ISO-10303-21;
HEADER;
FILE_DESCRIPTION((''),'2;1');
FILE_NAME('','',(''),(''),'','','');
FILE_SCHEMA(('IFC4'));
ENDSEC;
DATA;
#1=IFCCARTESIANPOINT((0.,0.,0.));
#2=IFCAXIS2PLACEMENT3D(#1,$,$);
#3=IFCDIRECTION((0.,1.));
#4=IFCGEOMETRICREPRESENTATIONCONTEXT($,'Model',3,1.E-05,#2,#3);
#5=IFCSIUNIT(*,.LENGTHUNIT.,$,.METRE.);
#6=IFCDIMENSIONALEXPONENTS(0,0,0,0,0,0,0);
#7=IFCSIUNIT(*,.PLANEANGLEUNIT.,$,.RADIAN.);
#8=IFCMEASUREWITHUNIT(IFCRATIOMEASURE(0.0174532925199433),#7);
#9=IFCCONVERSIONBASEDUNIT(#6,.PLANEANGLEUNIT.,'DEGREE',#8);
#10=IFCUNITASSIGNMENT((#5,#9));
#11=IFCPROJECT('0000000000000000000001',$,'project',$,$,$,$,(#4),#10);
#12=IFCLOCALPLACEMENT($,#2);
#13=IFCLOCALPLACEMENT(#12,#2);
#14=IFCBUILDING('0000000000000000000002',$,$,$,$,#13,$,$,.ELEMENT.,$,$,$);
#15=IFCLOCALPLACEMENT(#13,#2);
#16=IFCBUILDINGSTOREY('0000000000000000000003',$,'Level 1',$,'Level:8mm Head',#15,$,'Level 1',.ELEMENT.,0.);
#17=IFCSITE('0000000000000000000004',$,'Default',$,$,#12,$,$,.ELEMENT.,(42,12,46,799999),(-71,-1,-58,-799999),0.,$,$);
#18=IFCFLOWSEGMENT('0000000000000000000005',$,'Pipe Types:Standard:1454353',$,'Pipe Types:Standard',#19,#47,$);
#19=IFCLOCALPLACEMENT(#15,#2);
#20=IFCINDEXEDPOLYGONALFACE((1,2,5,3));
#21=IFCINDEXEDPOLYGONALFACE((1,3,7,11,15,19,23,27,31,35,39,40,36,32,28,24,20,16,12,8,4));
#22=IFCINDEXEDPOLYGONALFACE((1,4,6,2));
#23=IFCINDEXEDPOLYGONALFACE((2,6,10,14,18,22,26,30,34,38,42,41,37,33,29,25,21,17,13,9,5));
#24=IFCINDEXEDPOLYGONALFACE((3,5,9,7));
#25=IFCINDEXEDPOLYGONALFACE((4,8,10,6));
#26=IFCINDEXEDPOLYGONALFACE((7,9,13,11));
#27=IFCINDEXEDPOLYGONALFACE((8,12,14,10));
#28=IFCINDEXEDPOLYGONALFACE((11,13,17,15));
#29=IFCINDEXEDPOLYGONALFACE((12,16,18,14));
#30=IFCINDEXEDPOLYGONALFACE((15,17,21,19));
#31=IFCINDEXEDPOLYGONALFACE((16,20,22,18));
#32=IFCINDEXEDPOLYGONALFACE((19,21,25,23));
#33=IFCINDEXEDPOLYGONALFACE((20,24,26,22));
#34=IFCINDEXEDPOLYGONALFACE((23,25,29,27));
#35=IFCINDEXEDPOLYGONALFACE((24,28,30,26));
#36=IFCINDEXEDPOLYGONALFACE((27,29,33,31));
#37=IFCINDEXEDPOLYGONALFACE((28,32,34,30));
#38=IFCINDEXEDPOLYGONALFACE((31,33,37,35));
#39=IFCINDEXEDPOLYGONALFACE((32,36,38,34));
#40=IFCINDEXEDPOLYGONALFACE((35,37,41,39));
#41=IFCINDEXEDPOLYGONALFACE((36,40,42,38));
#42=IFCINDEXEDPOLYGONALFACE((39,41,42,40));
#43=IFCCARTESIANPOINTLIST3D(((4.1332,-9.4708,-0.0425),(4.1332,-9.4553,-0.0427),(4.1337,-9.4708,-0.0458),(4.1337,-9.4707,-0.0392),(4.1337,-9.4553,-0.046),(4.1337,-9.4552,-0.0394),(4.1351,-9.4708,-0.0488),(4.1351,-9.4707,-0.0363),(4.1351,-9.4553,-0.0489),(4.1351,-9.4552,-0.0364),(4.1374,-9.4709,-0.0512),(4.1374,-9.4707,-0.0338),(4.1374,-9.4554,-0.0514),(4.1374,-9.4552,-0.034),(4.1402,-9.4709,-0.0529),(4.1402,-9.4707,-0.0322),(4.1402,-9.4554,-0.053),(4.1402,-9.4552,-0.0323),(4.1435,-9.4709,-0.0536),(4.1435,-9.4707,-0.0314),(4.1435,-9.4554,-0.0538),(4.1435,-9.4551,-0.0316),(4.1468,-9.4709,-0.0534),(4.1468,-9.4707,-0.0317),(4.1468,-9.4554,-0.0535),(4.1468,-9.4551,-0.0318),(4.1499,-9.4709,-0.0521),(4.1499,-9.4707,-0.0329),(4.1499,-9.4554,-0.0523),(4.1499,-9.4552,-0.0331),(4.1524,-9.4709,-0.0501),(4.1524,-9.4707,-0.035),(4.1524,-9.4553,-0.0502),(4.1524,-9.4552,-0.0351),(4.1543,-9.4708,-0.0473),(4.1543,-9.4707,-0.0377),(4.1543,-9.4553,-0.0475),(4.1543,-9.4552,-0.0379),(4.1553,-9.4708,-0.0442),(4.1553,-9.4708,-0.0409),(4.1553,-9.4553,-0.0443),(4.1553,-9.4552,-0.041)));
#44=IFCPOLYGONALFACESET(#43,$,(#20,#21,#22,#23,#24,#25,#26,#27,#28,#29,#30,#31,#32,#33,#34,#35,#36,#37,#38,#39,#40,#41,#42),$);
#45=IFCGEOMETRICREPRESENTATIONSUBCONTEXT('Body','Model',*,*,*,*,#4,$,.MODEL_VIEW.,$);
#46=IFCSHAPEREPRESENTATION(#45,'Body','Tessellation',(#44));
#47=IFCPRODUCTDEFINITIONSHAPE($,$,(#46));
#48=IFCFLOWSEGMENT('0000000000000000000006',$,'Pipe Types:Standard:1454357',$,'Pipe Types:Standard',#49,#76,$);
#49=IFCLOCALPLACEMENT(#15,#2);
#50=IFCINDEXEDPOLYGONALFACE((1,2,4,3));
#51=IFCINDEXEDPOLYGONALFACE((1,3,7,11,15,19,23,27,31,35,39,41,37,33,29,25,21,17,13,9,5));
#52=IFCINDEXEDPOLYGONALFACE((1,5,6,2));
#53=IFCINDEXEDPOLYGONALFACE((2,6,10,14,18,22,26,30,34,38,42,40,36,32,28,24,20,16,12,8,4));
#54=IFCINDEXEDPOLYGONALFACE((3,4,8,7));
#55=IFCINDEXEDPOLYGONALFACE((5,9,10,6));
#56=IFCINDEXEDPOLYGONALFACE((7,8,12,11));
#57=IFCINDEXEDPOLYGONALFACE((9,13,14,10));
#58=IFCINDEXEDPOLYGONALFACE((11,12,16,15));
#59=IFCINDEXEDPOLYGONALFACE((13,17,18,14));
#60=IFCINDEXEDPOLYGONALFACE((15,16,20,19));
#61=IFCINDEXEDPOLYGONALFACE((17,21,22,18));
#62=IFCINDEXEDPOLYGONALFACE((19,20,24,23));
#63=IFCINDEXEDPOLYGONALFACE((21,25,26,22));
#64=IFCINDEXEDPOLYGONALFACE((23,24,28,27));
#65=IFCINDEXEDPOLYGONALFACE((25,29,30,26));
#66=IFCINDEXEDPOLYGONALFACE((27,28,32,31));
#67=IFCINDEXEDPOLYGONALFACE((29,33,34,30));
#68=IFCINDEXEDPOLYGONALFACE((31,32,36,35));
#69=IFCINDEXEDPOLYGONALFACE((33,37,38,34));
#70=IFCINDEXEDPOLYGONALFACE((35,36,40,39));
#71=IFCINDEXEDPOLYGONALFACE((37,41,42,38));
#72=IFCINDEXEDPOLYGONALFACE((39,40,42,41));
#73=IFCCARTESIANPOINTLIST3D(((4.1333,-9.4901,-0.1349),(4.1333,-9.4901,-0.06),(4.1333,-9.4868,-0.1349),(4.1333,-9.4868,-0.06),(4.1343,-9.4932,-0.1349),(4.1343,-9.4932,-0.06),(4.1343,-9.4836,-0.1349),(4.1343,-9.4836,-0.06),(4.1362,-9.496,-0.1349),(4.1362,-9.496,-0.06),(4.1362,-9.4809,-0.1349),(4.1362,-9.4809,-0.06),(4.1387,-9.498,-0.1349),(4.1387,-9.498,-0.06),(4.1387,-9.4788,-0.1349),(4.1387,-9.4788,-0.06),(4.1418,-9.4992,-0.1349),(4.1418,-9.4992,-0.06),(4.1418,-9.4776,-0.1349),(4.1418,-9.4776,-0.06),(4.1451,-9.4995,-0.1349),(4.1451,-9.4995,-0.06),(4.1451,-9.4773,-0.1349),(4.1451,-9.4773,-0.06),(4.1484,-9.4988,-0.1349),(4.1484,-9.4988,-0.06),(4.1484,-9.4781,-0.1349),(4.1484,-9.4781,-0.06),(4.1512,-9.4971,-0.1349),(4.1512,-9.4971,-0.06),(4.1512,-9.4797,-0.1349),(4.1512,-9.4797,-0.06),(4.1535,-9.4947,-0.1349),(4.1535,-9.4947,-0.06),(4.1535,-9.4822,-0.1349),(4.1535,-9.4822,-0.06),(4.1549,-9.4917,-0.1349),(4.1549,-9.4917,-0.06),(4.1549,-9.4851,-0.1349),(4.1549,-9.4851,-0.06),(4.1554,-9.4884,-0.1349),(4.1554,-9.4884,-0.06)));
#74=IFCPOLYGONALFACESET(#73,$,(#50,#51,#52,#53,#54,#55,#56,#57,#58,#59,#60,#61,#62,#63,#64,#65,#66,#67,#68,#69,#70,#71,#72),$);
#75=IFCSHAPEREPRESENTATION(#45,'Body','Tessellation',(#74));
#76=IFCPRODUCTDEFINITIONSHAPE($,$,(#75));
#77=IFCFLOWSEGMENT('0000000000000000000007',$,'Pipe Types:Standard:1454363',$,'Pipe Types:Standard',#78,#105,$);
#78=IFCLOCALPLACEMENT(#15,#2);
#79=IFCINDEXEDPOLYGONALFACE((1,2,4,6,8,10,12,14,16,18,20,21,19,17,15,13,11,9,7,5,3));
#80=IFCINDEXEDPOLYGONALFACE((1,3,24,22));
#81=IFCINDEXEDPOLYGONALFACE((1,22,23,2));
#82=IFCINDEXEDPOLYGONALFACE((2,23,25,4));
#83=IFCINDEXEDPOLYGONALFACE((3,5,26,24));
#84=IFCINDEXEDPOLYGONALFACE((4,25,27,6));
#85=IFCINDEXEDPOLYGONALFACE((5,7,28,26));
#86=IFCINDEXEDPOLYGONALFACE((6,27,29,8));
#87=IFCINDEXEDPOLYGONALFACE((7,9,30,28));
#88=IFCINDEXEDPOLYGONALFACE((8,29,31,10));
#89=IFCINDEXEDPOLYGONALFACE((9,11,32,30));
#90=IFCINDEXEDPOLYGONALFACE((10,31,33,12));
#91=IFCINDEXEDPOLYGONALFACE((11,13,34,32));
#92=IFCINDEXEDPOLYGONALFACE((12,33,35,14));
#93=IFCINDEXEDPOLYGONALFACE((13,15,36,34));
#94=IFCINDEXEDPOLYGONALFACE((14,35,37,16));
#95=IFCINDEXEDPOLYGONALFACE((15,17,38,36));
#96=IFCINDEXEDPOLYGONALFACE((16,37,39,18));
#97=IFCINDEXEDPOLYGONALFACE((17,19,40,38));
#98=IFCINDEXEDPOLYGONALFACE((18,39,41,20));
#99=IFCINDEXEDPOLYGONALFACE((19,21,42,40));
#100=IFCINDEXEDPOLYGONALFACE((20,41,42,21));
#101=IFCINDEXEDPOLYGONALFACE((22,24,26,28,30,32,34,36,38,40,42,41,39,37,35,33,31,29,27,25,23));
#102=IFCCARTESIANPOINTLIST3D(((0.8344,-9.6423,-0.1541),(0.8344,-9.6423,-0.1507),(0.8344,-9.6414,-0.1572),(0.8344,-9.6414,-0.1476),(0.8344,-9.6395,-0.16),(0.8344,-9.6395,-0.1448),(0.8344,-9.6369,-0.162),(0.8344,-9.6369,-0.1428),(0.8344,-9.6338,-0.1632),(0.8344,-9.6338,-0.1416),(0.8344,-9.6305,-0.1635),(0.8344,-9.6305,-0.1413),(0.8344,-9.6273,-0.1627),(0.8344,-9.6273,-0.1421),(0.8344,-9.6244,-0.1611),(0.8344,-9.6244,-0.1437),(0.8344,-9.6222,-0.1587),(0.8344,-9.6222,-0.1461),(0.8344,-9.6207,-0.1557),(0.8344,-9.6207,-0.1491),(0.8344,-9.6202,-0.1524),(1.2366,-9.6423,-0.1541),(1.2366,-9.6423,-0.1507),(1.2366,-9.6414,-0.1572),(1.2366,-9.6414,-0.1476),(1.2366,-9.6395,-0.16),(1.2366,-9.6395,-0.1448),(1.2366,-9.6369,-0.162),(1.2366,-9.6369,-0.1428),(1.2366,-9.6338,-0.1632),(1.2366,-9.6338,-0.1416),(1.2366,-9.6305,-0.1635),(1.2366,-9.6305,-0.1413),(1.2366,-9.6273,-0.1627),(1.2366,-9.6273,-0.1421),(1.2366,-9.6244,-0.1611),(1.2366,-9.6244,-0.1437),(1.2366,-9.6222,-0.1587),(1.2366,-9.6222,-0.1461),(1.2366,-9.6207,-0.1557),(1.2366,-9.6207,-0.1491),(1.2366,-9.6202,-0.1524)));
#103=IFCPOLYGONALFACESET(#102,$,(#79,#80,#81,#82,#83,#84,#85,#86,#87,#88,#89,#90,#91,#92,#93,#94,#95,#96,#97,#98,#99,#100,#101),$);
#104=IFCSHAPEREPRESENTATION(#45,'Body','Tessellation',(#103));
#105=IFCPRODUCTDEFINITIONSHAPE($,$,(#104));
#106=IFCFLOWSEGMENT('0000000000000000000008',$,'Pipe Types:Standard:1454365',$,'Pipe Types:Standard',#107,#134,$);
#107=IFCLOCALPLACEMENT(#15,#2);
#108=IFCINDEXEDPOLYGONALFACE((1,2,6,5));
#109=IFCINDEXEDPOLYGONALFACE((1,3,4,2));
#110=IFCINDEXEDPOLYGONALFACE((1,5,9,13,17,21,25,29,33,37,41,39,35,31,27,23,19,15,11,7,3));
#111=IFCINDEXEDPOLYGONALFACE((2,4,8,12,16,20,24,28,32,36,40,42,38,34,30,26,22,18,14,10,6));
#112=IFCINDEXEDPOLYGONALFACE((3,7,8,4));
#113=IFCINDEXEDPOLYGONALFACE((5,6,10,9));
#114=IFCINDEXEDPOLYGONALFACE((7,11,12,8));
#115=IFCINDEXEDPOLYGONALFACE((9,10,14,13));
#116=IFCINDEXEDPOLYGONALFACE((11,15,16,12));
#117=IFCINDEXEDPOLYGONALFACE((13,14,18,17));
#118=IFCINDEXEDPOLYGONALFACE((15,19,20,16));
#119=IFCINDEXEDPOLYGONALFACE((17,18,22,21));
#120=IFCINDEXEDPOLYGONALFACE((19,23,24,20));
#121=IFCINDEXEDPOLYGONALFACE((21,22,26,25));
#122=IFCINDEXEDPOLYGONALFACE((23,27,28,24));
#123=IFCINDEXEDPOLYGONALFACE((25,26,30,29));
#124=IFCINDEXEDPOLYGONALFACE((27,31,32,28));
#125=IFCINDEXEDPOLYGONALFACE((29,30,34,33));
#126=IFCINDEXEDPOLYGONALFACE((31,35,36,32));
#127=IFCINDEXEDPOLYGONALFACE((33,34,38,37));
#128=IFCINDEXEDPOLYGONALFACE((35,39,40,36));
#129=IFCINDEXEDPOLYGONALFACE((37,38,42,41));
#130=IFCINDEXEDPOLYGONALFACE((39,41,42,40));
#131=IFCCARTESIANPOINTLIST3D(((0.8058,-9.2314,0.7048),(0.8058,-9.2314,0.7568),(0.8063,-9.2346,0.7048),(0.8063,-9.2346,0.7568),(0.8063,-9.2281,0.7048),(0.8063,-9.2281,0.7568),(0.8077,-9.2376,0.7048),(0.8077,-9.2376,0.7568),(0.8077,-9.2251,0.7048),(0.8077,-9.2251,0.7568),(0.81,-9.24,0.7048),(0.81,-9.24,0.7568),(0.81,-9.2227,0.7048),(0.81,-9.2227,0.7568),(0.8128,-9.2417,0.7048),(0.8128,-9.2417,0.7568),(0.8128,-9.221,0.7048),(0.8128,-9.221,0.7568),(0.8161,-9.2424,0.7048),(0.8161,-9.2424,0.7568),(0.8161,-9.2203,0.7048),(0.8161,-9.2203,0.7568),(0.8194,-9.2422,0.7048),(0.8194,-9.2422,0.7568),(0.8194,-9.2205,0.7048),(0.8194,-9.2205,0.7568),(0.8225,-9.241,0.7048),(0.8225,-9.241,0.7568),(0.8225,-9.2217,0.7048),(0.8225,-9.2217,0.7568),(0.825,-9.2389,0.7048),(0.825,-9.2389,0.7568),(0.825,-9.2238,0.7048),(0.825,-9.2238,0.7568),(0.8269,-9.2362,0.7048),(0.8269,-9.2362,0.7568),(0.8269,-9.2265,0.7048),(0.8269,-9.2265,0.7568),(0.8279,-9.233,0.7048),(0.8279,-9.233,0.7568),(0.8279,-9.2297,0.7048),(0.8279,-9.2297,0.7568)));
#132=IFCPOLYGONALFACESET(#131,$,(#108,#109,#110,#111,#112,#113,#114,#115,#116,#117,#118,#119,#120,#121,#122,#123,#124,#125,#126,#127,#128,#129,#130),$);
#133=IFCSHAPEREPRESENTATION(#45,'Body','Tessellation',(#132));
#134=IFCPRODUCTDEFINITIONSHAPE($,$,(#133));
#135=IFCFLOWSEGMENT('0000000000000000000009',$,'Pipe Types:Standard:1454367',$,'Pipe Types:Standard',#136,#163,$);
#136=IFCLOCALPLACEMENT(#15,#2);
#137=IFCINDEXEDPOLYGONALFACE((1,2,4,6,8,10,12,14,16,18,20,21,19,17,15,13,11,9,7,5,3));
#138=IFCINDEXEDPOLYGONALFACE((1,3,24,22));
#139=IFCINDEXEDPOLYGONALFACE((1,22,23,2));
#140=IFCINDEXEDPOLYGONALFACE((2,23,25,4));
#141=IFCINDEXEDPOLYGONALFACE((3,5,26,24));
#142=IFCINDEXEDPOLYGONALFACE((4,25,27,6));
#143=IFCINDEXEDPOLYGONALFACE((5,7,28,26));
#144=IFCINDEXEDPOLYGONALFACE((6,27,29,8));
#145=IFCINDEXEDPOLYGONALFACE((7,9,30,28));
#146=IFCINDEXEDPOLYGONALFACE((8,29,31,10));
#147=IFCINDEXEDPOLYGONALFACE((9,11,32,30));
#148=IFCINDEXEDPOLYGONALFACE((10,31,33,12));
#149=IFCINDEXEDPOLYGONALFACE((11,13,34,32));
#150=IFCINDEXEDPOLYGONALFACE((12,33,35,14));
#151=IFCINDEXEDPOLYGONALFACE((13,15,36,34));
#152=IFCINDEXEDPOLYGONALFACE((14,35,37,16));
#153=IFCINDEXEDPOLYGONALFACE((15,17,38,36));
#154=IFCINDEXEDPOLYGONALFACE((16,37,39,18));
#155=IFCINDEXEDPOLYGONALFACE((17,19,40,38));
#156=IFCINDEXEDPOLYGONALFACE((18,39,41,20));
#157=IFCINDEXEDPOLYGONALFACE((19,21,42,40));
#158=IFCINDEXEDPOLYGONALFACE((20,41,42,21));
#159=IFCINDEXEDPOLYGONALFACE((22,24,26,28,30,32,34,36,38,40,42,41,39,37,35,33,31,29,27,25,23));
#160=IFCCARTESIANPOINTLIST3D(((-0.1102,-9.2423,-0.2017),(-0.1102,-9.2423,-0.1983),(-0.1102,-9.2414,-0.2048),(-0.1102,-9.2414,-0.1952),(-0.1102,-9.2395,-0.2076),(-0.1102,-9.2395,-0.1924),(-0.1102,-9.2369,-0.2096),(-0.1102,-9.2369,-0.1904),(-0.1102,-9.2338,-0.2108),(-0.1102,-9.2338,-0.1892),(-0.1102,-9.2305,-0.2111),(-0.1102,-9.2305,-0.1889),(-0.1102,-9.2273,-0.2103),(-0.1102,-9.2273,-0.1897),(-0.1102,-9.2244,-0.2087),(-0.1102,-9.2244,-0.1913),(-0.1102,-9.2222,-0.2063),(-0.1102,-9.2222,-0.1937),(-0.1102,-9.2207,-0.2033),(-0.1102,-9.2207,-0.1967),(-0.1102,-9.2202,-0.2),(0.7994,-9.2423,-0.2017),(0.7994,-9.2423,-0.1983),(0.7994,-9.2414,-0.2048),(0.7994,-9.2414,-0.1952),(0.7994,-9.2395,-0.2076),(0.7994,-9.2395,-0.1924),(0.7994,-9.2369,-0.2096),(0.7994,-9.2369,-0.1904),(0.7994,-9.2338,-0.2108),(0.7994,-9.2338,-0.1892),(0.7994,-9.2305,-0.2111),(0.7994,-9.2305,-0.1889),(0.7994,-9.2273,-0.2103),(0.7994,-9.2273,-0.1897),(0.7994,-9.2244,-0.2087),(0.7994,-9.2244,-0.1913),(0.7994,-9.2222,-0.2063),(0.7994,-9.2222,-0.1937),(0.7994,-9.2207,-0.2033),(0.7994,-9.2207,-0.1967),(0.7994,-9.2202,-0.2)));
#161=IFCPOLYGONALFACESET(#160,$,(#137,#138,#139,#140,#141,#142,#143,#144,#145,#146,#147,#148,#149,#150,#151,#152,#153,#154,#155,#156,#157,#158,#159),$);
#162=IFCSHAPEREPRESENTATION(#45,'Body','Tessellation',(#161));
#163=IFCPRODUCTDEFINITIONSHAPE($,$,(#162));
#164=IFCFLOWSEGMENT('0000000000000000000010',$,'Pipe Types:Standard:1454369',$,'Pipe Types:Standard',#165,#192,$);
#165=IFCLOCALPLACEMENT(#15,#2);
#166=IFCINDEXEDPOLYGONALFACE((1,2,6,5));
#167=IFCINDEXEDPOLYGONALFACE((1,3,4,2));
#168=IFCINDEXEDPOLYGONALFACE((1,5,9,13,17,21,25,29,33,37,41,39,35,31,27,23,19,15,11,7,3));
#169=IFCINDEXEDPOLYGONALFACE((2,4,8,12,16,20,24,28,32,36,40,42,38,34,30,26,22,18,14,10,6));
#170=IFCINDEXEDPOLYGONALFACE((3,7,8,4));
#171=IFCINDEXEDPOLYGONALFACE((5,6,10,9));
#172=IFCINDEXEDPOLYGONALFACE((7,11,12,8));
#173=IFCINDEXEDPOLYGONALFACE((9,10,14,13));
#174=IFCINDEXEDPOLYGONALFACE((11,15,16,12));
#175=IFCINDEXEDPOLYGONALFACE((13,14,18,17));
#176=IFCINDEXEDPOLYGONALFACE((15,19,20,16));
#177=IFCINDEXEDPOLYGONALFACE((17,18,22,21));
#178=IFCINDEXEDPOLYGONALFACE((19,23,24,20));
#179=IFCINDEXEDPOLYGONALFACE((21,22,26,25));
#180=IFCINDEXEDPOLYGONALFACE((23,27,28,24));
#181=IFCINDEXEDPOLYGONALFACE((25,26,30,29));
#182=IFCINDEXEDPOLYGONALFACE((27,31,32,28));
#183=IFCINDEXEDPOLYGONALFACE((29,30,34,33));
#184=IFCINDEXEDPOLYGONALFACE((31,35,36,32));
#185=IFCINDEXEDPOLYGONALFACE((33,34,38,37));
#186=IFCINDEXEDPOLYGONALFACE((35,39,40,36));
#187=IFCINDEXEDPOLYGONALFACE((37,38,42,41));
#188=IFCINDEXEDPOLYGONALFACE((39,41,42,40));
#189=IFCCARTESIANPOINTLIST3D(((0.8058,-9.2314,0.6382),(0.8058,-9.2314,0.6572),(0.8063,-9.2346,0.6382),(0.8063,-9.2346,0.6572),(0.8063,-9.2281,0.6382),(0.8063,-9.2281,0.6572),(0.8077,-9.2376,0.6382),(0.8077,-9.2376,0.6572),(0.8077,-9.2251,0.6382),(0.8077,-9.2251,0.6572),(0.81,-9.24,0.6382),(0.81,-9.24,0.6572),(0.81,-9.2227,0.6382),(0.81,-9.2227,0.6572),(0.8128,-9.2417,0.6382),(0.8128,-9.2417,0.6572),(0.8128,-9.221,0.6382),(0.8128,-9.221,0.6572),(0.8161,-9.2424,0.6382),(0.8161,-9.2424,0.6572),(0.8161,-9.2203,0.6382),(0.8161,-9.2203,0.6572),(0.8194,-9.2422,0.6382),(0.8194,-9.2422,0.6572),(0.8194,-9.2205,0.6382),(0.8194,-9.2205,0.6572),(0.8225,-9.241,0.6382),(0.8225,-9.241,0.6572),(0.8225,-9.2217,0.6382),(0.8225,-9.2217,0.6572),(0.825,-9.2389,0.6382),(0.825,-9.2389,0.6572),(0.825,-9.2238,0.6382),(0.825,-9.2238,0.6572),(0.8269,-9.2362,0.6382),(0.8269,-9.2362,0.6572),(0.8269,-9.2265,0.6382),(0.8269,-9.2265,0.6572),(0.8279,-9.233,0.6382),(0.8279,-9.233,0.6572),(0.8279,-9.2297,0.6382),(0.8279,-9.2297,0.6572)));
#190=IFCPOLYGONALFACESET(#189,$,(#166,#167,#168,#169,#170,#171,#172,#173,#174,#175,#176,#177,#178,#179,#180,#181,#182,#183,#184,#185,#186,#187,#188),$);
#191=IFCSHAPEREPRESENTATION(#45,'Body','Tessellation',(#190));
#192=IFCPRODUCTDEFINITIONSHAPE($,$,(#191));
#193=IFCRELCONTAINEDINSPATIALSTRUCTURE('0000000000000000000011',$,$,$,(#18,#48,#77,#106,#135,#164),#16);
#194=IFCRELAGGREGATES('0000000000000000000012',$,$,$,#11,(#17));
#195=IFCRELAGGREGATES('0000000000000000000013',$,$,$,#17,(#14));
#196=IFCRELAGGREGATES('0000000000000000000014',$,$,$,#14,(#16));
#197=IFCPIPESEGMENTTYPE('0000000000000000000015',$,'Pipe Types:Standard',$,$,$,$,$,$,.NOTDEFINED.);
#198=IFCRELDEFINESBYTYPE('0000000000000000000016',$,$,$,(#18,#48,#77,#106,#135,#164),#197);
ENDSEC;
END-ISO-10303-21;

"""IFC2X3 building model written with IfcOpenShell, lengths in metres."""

from ifc_helpers import new_model, entity, si_unit, converted_unit, direction, frame, frame_2d, origin, origin_2d_with_axis, place, context, subcontext, project, spatial, circle, extrude, type_object, element, save


model = new_model("IFC2X3")

# Units and contexts
model_context = context("Model", 3, precision=1e-05, world=origin(), true_north=direction((0.0, 1.0)))
body_context = subcontext(model_context, "Body", "Model", "MODEL_VIEW")
ifc_project = project(units=[si_unit("LENGTHUNIT", "METRE"), converted_unit("PLANEANGLEUNIT", "DEGREE", entity("IfcRatioMeasure", 0.0174532925199433), si_unit("PLANEANGLEUNIT", "RADIAN"), dimensions=[0, 0, 0, 0, 0, 0, 0])], contexts=[model_context])

# Site, building, storey
site_placement = place(None, origin())
site = spatial("IfcSite", under=ifc_project, at=site_placement, Name="Default", CompositionType="ELEMENT", RefLatitude=(42, 12, 46, 799999), RefLongitude=(-71, -1, -58, -799999), RefElevation=0.0)
building_placement = place(site_placement, origin())
building = spatial("IfcBuilding", under=site, at=building_placement, CompositionType="ELEMENT")
storey_placement = place(building_placement, origin())
storey = spatial("IfcBuildingStorey", under=building, at=storey_placement, Name="Level 1", ObjectType="Level:8mm Head", LongName="Level 1", CompositionType="ELEMENT", Elevation=0.0)

# Flow segments
pipe_segment_type = type_object("IfcPipeSegmentType", Name="Pipe Types:Standard", PredefinedType="NOTDEFINED")
flow_segment_1_placement = place(storey_placement, origin())
element("IfcFlowSegment", 1, at=flow_segment_1_placement, inside=storey, type_object=pipe_segment_type, Name="Pipe Types:Standard:1454353", ObjectType="Pipe Types:Standard", context=body_context, shape_type="SweptSolid", body=[
    extrude(circle(Radius=0.0111, at=frame_2d((0.0, 0.0), x_axis=(1.0, 0.0))), frame((4.1443, -9.4553, -0.0427), z_axis=(0.0, -0.999946, 0.010416), x_axis=(-1.0, 0.0, 0.0)), (0.0, 0.0, 1.0), 0.0155),
])
flow_segment_2_placement = place(storey_placement, origin())
element("IfcFlowSegment", 2, at=flow_segment_2_placement, inside=storey, type_object=pipe_segment_type, Name="Pipe Types:Standard:1454357", ObjectType="Pipe Types:Standard", context=body_context, shape_type="SweptSolid", body=[
    extrude(circle(Radius=0.0111, at=frame_2d((0.0, 0.0), x_axis=(1.0, 0.0))), frame((4.1443, -9.4884, -0.1349)), (0.0, 0.0, 1.0), 0.075),
])
flow_segment_3_placement = place(storey_placement, origin())
element("IfcFlowSegment", 3, at=flow_segment_3_placement, inside=storey, type_object=pipe_segment_type, Name="Pipe Types:Standard:1454363", ObjectType="Pipe Types:Standard", context=body_context, shape_type="SweptSolid", body=[
    extrude(circle(Radius=0.0111, at=frame_2d((0.0, 0.0), x_axis=(1.0, 0.0))), frame((0.8344, -9.6314, -0.1524), z_axis=(1.0, 0.0, 0.0), x_axis=(0.0, 1.0, 0.0)), (0.0, 0.0, 1.0), 0.4022),
])
flow_segment_4_placement = place(storey_placement, origin())
element("IfcFlowSegment", 4, at=flow_segment_4_placement, inside=storey, type_object=pipe_segment_type, Name="Pipe Types:Standard:1454365", ObjectType="Pipe Types:Standard", context=body_context, shape_type="SweptSolid", body=[
    extrude(circle(Radius=0.0111, at=origin_2d_with_axis()), frame((0.8169, -9.2314, 0.7048), z_axis=(0.0, 0.0, 1.0), x_axis=(-1.0, 0.0, 0.0)), (0.0, 0.0, 1.0), 0.052),
])
flow_segment_5_placement = place(storey_placement, origin())
element("IfcFlowSegment", 5, at=flow_segment_5_placement, inside=storey, type_object=pipe_segment_type, Name="Pipe Types:Standard:1454367", ObjectType="Pipe Types:Standard", context=body_context, shape_type="SweptSolid", body=[
    extrude(circle(Radius=0.0111, at=frame_2d((0.0, 0.0), x_axis=(1.0, 0.0))), frame((-0.1102, -9.2314, -0.2), z_axis=(1.0, 0.0, 0.0), x_axis=(0.0, 1.0, 0.0)), (0.0, 0.0, 1.0), 0.9096),
])
flow_segment_6_placement = place(storey_placement, origin())
element("IfcFlowSegment", 6, at=flow_segment_6_placement, inside=storey, type_object=pipe_segment_type, Name="Pipe Types:Standard:1454369", ObjectType="Pipe Types:Standard", context=body_context, shape_type="SweptSolid", body=[
    extrude(circle(Radius=0.0111, at=origin_2d_with_axis()), frame((0.8169, -9.2314, 0.6382), z_axis=(0.0, 0.0, 1.0), x_axis=(-1.0, 0.0, 0.0)), (0.0, 0.0, 1.0), 0.019),
])

save(model, "model.ifc")
